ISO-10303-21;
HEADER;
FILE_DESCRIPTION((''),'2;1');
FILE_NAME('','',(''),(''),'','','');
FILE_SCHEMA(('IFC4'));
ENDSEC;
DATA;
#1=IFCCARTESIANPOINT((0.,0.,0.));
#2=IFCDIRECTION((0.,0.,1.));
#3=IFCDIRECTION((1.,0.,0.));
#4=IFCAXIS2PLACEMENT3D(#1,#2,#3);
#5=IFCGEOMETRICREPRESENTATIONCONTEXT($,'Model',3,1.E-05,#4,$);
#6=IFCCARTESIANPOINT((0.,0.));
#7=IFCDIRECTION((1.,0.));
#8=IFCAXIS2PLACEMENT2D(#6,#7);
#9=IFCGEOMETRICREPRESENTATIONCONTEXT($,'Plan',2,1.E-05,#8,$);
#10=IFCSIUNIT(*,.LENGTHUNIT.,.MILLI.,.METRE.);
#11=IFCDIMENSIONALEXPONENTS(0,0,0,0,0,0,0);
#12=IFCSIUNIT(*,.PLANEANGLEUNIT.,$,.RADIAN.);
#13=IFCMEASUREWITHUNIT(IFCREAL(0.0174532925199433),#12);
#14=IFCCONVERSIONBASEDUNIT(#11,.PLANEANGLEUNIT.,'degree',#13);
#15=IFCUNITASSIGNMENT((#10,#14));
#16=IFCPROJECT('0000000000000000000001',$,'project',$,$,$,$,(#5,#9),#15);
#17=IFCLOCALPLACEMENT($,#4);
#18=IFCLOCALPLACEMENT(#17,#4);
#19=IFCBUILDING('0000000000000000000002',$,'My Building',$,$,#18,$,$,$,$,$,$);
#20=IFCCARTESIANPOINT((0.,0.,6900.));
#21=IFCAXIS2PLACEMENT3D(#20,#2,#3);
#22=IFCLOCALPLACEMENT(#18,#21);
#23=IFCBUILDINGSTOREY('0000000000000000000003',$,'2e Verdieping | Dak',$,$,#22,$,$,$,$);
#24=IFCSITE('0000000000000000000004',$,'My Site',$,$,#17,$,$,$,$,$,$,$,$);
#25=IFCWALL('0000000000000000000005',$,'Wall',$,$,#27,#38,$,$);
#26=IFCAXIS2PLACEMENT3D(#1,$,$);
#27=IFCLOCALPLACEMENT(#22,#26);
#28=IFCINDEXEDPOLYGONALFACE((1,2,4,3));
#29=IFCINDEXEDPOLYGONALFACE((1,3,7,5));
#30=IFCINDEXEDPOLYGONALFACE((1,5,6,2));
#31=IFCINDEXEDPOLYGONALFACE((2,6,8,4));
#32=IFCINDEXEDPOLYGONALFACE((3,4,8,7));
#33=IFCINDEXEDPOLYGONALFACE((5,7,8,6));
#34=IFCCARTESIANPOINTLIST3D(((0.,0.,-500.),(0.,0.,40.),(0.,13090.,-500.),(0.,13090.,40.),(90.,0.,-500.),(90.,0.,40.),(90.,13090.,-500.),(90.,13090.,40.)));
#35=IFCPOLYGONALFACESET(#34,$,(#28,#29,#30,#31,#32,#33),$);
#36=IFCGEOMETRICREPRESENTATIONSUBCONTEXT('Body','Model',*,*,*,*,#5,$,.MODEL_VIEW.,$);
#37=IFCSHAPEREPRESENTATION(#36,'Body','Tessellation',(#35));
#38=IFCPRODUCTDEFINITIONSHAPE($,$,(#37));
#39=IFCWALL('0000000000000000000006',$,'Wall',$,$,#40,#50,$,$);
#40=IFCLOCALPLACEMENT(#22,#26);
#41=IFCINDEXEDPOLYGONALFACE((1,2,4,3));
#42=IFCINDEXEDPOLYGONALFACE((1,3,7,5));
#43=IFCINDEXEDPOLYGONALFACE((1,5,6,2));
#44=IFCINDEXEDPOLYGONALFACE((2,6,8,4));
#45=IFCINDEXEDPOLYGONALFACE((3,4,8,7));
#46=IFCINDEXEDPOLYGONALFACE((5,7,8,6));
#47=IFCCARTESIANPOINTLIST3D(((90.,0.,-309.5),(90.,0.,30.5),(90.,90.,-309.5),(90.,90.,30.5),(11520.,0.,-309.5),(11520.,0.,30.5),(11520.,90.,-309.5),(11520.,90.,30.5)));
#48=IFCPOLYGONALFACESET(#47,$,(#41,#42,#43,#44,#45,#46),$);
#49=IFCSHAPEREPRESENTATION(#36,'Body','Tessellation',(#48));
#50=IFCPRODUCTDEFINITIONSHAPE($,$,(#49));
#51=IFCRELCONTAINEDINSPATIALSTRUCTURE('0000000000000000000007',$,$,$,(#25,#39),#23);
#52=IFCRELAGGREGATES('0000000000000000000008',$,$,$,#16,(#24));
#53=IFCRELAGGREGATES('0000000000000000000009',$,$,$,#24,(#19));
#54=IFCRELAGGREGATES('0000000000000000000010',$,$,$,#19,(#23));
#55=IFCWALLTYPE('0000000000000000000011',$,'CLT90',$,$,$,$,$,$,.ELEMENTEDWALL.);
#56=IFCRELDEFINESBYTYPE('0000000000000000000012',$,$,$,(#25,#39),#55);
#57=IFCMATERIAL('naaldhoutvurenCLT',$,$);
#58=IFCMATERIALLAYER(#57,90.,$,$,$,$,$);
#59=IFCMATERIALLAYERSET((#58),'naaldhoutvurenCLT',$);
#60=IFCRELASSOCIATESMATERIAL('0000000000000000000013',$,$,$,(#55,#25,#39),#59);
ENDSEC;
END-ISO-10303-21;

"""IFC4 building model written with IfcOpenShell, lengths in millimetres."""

from ifc_helpers import new_model, entity, si_unit, converted_unit, frame, origin_with_axes, origin_2d_with_axis, place, context, subcontext, project, spatial, indexed_curve, outline, extrude, material, layer, layer_set, layer_usage, type_object, element, save


model = new_model("IFC4")

# Units and contexts
model_context = context("Model", 3, precision=1e-05, world=origin_with_axes())
plan_context = context("Plan", 2, precision=1e-05, world=origin_2d_with_axis())
body_context = subcontext(model_context, "Body", "Model", "MODEL_VIEW")
ifc_project = project(units=[si_unit("LENGTHUNIT", "METRE", prefix="MILLI"), converted_unit("PLANEANGLEUNIT", "degree", entity("IfcReal", 0.0174532925199433), si_unit("PLANEANGLEUNIT", "RADIAN"), dimensions=[0, 0, 0, 0, 0, 0, 0])], contexts=[model_context, plan_context])

# Site, building, storey
site_placement = place(None, origin_with_axes())
site = spatial("IfcSite", under=ifc_project, at=site_placement, Name="My Site")
building_placement = place(site_placement, origin_with_axes())
building = spatial("IfcBuilding", under=site, at=building_placement, Name="My Building")
storey_placement = place(building_placement, frame((0.0, 0.0, 6900.0), z_axis=(0.0, 0.0, 1.0), x_axis=(1.0, 0.0, 0.0)))
storey = spatial("IfcBuildingStorey", under=building, at=storey_placement, Name="2e Verdieping | Dak")

# Shared definitions
ifc_material_1 = material(Name="naaldhoutvurenCLT")

# Walls
ifc_layer_1 = layer(ifc_material_1, 90.0)
ifc_layer_set_1 = layer_set([ifc_layer_1], Name="naaldhoutvurenCLT")
wall_type = type_object("IfcWallType", Name="CLT90", PredefinedType="ELEMENTEDWALL", material=ifc_layer_set_1)
ifc_layer_usage_1 = layer_usage(ifc_layer_set_1, "AXIS2", "POSITIVE", 0.0)
wall_1_placement = place(storey_placement, frame((90.0, 0.0, -500.0), z_axis=(0.0, 0.0, 1.0), x_axis=(0.0, 1.0, 0.0)))
element("IfcWall", 1, at=wall_1_placement, inside=storey, type_object=wall_type, material=ifc_layer_usage_1, Name="Wall", context=body_context, shape_type="SweptSolid", body=[
    extrude(outline(indexed_curve([(0.0, 0.0), (0.0, 90.0), (13090.0, 90.0), (13090.0, 0.0), (0.0, 0.0)], self_intersect=False)), origin_with_axes(), (0.0, 0.0, 1.0), 540.0),
])
ifc_layer_usage_2 = layer_usage(ifc_layer_set_1, "AXIS2", "POSITIVE", 0.0)
wall_2_placement = place(storey_placement, frame((11520.0, 90.0, -309.5), z_axis=(0.0, 0.0, 1.0), x_axis=(-1.0, 0.000001, 0.0)))
element("IfcWall", 2, at=wall_2_placement, inside=storey, type_object=wall_type, material=ifc_layer_usage_2, Name="Wall", context=body_context, shape_type="SweptSolid", body=[
    extrude(outline(indexed_curve([(0.0, 0.0), (0.0, 90.0), (11430.0, 90.0), (11430.0, 0.0), (0.0, 0.0)], self_intersect=False)), origin_with_axes(), (0.0, 0.0, 1.0), 340.0),
])

save(model, "model.ifc")
